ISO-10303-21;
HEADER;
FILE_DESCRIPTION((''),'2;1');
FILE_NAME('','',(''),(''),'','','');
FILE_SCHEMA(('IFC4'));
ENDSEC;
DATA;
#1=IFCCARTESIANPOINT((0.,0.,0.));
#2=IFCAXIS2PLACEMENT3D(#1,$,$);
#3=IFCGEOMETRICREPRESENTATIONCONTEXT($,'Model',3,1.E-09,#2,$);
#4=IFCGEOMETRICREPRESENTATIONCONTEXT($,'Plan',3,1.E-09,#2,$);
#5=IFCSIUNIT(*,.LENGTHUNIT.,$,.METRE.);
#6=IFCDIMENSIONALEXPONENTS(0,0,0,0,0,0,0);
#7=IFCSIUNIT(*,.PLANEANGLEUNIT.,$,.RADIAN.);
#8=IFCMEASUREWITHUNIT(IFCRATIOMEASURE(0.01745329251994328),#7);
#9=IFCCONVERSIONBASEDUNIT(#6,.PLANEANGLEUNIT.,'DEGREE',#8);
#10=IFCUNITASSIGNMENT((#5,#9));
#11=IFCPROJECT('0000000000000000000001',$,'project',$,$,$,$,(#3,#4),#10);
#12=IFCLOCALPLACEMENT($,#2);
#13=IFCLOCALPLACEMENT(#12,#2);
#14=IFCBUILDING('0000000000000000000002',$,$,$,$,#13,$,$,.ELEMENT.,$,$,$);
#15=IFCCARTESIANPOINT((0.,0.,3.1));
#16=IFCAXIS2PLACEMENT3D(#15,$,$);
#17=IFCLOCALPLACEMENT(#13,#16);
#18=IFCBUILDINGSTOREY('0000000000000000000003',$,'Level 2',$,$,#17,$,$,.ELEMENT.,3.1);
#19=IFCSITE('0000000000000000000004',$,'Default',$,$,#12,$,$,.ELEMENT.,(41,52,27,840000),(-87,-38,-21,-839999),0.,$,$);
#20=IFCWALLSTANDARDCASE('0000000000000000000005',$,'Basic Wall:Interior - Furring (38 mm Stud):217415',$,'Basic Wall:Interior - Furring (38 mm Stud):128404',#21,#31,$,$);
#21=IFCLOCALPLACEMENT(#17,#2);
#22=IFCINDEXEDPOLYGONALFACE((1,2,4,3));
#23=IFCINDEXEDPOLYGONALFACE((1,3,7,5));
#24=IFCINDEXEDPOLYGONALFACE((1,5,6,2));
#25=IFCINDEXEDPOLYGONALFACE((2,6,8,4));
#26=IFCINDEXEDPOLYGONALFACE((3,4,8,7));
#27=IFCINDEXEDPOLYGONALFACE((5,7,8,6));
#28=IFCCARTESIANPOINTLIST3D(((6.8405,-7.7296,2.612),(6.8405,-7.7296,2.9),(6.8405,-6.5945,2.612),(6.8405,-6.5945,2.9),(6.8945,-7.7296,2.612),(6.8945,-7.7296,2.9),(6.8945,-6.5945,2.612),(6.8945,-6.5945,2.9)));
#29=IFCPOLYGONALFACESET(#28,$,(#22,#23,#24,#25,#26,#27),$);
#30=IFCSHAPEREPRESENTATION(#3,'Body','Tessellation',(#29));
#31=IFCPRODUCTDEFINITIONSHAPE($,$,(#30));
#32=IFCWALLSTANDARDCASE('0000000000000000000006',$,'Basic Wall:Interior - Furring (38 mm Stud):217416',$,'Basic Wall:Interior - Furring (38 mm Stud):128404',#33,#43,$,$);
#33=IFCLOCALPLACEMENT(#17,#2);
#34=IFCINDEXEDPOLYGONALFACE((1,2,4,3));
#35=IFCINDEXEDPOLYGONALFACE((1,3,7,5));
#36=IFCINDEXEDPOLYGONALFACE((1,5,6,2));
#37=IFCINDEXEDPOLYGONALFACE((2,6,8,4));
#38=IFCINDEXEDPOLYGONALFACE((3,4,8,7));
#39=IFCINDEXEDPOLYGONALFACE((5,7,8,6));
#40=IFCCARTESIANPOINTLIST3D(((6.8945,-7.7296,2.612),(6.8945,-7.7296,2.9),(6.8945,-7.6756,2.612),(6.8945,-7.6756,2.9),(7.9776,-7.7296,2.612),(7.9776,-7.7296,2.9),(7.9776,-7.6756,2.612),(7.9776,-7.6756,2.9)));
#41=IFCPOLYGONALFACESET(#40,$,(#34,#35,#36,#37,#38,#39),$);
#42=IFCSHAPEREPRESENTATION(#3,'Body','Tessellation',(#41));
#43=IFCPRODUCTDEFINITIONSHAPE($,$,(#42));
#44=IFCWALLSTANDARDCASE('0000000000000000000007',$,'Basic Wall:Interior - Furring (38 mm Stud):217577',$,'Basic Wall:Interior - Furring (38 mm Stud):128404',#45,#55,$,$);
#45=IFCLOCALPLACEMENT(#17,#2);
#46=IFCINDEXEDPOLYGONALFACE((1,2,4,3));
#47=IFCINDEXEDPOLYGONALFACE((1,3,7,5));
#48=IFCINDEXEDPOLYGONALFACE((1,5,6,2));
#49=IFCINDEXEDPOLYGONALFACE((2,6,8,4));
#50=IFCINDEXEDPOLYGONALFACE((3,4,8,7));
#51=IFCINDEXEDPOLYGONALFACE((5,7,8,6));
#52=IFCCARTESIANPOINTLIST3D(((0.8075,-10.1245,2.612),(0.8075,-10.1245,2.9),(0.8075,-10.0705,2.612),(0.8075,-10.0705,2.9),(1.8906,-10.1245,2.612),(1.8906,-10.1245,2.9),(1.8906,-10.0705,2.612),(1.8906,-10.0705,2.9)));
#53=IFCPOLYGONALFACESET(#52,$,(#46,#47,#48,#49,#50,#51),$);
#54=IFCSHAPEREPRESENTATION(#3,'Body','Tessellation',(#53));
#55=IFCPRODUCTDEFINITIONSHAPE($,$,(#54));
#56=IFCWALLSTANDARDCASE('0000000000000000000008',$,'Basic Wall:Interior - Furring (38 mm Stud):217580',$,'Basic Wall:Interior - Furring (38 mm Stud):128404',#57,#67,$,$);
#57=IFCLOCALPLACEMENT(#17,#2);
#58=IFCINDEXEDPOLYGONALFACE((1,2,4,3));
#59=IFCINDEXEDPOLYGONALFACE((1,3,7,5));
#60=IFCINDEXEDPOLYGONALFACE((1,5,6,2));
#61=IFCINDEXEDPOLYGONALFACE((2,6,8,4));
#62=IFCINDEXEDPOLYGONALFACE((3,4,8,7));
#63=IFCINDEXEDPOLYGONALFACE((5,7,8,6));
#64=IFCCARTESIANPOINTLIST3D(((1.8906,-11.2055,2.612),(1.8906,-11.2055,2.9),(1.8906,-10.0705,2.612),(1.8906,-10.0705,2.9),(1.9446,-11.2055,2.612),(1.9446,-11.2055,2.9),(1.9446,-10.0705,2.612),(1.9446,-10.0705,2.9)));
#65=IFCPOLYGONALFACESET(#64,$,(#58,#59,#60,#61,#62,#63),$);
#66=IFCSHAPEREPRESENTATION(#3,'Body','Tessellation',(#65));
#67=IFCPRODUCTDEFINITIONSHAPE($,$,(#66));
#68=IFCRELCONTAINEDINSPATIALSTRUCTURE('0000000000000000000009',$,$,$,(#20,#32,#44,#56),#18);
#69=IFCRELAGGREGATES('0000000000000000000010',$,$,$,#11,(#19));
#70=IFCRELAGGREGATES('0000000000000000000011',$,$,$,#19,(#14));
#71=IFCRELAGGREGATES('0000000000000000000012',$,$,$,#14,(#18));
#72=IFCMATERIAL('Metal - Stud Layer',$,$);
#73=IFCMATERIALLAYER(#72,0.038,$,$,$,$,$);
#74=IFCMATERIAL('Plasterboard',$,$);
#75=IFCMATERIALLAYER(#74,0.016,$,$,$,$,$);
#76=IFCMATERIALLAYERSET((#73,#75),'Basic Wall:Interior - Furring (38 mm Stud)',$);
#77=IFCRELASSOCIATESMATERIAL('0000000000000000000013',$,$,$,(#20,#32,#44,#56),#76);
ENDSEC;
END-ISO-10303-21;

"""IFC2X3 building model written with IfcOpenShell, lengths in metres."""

from ifc_helpers import new_model, entity, si_unit, converted_unit, frame, frame_2d, origin, place, context, project, spatial, rectangle, extrude, material, layer, layer_set, layer_usage, element, save


model = new_model("IFC2X3")

# Units and contexts
model_context = context("Model", 3, precision=1e-09, world=origin())
plan_context = context("Plan", 3, precision=1e-09, world=origin())
ifc_project = project(units=[si_unit("LENGTHUNIT", "METRE"), converted_unit("PLANEANGLEUNIT", "DEGREE", entity("IfcRatioMeasure", 0.01745329251994328), si_unit("PLANEANGLEUNIT", "RADIAN"), dimensions=[0, 0, 0, 0, 0, 0, 0])], contexts=[model_context, plan_context])

# Site, building, storey
site_placement = place(None, origin())
site = spatial("IfcSite", under=ifc_project, at=site_placement, Name="Default", CompositionType="ELEMENT", RefLatitude=(41, 52, 27, 840000), RefLongitude=(-87, -38, -21, -839999), RefElevation=0.0)
building_placement = place(site_placement, origin())
building = spatial("IfcBuilding", under=site, at=building_placement, CompositionType="ELEMENT")
storey_placement = place(building_placement, frame((0.0, 0.0, 3.1)))
storey = spatial("IfcBuildingStorey", under=building, at=storey_placement, Name="Level 2", CompositionType="ELEMENT", Elevation=3.1)

# Shared definitions
ifc_material_1 = material(Name="Plasterboard")
ifc_material_2 = material(Name="Metal - Stud Layer")

# Walls
ifc_layer_1 = layer(ifc_material_2, 0.038)
ifc_layer_2 = layer(ifc_material_1, 0.016)
ifc_layer_set_1 = layer_set([ifc_layer_1, ifc_layer_2], Name="Basic Wall:Interior - Furring (38 mm Stud)")
ifc_layer_usage_1 = layer_usage(ifc_layer_set_1, "AXIS2", "NEGATIVE", 0.027)
wall_1_placement = place(storey_placement, frame((6.8675, -7.7296, 2.612), z_axis=(0.0, 0.0, 1.0), x_axis=(0.0, 1.0, 0.0)))
element("IfcWallStandardCase", 1, at=wall_1_placement, inside=storey, material=ifc_layer_usage_1, Name="Basic Wall:Interior - Furring (38 mm Stud):217415", ObjectType="Basic Wall:Interior - Furring (38 mm Stud):128404", context=model_context, shape_type="SweptSolid", body=[
    extrude(rectangle(XDim=1.1351, YDim=0.054, at=frame_2d((0.5675, 0.0), x_axis=(-1.0, 0.0))), origin(), (0.0, 0.0, 1.0), 0.288),
])
ifc_layer_usage_2 = layer_usage(ifc_layer_set_1, "AXIS2", "NEGATIVE", 0.027)
wall_2_placement = place(storey_placement, frame((7.9776, -7.7026, 2.612), z_axis=(0.0, 0.0, 1.0), x_axis=(-1.0, 0.0, 0.0)))
element("IfcWallStandardCase", 2, at=wall_2_placement, inside=storey, material=ifc_layer_usage_2, Name="Basic Wall:Interior - Furring (38 mm Stud):217416", ObjectType="Basic Wall:Interior - Furring (38 mm Stud):128404", context=model_context, shape_type="SweptSolid", body=[
    extrude(rectangle(XDim=1.0831, YDim=0.054, at=frame_2d((0.5416, 0.0), x_axis=(-1.0, 0.0))), origin(), (0.0, 0.0, 1.0), 0.288),
])
ifc_layer_usage_3 = layer_usage(ifc_layer_set_1, "AXIS2", "NEGATIVE", 0.027)
wall_3_placement = place(storey_placement, frame((0.8075, -10.0975, 2.612)))
element("IfcWallStandardCase", 3, at=wall_3_placement, inside=storey, material=ifc_layer_usage_3, Name="Basic Wall:Interior - Furring (38 mm Stud):217577", ObjectType="Basic Wall:Interior - Furring (38 mm Stud):128404", context=model_context, shape_type="SweptSolid", body=[
    extrude(rectangle(XDim=1.0831, YDim=0.054, at=frame_2d((0.5415, 0.0), x_axis=(-1.0, 0.0))), origin(), (0.0, 0.0, 1.0), 0.288),
])
ifc_layer_usage_4 = layer_usage(ifc_layer_set_1, "AXIS2", "NEGATIVE", 0.027)
wall_4_placement = place(storey_placement, frame((1.9176, -10.0705, 2.612), z_axis=(0.0, 0.0, 1.0), x_axis=(0.0, -1.0, 0.0)))
element("IfcWallStandardCase", 4, at=wall_4_placement, inside=storey, material=ifc_layer_usage_4, Name="Basic Wall:Interior - Furring (38 mm Stud):217580", ObjectType="Basic Wall:Interior - Furring (38 mm Stud):128404", context=model_context, shape_type="SweptSolid", body=[
    extrude(rectangle(XDim=1.1351, YDim=0.054, at=frame_2d((0.5675, 0.0), x_axis=(-1.0, 0.0))), origin(), (0.0, 0.0, 1.0), 0.288),
])

save(model, "model.ifc")
